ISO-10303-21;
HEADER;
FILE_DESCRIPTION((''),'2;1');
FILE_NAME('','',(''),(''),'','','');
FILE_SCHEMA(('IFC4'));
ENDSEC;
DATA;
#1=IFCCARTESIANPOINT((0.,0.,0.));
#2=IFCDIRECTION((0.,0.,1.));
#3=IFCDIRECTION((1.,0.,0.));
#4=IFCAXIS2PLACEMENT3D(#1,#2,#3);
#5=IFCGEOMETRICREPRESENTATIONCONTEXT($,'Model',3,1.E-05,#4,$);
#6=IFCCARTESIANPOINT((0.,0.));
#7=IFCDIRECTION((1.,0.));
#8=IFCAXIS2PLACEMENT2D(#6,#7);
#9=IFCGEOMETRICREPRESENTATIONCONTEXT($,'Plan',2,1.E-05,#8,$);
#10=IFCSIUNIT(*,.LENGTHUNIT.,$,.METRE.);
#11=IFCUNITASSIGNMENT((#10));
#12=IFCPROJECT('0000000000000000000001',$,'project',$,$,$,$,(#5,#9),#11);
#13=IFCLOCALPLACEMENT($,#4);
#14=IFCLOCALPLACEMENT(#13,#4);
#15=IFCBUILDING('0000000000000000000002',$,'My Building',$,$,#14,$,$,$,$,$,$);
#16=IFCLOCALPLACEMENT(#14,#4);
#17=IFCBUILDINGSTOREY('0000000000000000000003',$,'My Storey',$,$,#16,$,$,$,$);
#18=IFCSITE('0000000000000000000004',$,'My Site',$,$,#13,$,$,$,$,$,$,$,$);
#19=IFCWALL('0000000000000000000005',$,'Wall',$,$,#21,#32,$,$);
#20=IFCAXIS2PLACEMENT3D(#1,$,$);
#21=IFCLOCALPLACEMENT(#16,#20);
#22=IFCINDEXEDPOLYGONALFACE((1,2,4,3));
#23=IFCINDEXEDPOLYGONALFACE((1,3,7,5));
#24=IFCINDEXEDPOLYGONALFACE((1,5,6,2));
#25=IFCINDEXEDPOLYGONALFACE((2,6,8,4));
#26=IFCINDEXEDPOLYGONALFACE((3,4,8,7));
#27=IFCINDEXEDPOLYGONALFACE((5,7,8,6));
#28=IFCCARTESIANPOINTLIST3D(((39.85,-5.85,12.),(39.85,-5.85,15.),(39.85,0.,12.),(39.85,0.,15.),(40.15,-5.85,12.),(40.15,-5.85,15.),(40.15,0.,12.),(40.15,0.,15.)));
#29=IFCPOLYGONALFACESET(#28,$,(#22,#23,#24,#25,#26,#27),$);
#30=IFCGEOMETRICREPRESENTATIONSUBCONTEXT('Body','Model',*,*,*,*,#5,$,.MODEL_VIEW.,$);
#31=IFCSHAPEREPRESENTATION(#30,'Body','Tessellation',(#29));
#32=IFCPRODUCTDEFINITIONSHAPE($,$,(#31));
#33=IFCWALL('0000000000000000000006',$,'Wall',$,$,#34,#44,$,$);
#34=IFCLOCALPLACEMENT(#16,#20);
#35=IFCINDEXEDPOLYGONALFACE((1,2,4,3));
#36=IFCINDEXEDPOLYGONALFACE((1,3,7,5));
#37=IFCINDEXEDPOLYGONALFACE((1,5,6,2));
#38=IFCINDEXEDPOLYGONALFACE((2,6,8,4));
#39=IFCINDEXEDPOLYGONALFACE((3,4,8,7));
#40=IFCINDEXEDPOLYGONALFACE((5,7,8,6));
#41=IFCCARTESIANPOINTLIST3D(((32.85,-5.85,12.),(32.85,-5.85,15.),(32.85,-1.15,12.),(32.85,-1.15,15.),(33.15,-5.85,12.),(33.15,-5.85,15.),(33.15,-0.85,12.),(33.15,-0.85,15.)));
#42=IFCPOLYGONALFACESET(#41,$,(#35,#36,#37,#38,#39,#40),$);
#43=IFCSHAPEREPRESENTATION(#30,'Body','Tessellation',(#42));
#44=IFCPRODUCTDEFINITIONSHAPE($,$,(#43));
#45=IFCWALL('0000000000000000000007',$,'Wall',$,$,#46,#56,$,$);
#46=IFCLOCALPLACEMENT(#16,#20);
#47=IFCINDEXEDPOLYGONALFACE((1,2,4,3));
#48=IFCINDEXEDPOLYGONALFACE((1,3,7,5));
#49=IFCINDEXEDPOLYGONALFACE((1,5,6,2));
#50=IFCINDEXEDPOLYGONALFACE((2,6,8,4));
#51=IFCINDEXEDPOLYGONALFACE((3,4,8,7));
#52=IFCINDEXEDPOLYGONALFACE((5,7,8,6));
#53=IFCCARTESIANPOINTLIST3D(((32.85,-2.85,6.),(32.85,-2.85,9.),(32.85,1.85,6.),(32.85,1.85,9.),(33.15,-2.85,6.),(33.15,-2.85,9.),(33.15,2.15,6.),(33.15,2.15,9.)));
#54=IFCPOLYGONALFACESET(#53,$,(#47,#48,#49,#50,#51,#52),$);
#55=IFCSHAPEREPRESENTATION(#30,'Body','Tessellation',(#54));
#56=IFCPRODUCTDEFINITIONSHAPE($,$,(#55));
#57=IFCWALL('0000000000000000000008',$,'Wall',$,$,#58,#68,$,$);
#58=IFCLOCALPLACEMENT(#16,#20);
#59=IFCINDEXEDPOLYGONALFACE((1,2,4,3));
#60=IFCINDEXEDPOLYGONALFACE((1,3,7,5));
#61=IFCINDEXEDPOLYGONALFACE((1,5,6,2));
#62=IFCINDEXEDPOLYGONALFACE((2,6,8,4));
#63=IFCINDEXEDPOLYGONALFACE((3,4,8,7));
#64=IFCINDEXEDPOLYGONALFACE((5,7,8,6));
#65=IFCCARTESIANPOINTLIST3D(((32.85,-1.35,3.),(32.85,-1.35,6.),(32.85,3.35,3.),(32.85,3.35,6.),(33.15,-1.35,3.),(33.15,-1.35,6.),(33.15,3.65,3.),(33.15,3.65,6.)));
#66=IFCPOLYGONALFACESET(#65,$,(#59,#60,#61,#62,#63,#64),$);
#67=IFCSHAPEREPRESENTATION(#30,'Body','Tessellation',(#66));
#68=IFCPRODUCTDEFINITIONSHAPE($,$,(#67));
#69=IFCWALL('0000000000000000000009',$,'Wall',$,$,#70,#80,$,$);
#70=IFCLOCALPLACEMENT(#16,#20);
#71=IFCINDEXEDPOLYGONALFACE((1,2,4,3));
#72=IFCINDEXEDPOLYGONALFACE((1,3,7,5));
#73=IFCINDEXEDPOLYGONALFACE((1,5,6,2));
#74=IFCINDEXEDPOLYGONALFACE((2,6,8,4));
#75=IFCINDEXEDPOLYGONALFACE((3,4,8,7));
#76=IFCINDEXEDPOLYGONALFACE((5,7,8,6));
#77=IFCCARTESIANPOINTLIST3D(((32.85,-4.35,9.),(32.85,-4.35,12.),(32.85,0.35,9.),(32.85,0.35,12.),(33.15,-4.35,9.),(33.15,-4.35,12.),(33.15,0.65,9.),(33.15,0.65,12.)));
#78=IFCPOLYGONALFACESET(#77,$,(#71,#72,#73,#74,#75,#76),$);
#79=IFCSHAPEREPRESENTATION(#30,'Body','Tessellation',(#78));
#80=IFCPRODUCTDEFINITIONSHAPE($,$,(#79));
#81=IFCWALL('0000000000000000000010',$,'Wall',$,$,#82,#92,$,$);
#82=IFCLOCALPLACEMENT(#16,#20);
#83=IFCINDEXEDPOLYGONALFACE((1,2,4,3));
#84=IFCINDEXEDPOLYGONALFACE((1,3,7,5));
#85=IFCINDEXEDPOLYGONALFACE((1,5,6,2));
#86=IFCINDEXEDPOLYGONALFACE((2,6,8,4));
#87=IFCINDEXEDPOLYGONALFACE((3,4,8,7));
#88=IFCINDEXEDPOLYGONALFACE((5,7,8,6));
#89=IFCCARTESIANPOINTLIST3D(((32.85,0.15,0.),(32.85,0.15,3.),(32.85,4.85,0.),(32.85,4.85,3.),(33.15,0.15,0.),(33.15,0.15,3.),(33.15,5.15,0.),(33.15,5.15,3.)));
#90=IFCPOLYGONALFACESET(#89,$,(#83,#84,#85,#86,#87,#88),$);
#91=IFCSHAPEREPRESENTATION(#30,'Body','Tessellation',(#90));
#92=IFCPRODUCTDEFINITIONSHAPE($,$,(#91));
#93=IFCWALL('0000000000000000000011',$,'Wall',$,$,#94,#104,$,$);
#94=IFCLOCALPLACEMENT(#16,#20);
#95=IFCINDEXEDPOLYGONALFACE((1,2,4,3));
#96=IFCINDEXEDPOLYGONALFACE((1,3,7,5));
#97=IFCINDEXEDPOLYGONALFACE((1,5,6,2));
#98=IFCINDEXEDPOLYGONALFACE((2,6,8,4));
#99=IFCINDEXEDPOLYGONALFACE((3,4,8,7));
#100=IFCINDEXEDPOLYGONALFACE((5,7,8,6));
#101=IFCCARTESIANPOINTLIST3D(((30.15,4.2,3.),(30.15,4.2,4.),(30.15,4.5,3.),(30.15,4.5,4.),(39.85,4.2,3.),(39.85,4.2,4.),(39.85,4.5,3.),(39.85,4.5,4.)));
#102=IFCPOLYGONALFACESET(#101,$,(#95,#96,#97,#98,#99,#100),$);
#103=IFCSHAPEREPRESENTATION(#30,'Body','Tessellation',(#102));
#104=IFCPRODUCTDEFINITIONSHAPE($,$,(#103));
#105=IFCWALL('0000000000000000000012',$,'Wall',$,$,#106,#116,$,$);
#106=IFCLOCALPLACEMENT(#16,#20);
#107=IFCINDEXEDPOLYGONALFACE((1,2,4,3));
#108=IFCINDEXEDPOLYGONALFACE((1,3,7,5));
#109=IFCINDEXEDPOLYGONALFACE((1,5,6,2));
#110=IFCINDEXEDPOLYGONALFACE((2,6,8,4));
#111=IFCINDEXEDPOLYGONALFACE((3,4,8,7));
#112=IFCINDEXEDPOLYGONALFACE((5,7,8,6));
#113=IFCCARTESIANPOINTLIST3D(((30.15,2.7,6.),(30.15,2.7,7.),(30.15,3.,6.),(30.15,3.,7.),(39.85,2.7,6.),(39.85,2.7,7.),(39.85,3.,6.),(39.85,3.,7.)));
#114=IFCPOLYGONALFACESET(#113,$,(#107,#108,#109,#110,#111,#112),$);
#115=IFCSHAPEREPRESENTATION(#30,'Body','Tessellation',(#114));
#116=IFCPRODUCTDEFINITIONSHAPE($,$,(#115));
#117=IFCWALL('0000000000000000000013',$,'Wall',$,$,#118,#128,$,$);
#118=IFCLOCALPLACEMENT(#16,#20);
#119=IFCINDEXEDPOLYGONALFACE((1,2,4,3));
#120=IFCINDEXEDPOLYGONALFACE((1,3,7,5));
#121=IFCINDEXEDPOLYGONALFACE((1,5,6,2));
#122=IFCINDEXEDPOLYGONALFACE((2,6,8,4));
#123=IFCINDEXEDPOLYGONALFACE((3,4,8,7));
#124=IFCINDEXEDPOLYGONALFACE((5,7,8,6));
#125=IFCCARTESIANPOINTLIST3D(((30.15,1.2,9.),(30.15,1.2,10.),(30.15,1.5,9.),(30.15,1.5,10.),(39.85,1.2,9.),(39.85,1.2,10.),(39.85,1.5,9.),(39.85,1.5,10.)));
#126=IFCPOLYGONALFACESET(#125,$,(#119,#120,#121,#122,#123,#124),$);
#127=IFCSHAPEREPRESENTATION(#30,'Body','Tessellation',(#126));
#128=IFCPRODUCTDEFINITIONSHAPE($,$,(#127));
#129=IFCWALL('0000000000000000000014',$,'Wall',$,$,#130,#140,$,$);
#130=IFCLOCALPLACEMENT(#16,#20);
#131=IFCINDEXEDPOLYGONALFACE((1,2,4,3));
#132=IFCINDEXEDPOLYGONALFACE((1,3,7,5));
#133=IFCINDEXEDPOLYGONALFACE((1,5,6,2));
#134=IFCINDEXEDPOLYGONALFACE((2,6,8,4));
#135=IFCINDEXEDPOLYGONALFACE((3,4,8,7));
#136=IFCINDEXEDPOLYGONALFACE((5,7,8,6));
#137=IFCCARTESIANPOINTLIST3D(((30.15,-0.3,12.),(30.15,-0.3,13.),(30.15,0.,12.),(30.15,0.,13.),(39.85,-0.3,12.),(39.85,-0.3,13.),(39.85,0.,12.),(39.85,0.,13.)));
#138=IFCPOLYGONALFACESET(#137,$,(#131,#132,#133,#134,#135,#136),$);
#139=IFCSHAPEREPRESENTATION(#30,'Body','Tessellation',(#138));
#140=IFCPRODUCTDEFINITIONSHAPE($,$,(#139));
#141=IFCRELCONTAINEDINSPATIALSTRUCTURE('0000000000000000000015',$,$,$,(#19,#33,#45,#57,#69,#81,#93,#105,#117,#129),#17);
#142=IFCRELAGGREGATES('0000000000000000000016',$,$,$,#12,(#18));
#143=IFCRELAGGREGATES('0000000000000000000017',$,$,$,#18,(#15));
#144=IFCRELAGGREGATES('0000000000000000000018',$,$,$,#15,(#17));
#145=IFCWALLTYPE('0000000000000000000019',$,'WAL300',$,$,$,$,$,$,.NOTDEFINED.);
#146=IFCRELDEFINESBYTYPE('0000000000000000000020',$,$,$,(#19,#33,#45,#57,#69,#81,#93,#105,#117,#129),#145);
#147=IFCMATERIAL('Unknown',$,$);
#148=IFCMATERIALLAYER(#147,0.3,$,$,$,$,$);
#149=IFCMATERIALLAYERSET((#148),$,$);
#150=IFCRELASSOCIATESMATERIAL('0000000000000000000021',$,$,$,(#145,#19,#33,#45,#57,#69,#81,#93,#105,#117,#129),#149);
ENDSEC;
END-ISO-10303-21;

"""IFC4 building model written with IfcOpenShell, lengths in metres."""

from ifc_helpers import new_model, si_unit, frame, origin_with_axes, origin_2d_with_axis, place, context, subcontext, project, spatial, line, indexed_curve, outline, extrude, material, layer, layer_set, layer_usage, type_object, element, save


model = new_model("IFC4")

# Units and contexts
model_context = context("Model", 3, precision=1e-05, world=origin_with_axes())
plan_context = context("Plan", 2, precision=1e-05, world=origin_2d_with_axis())
body_context = subcontext(model_context, "Body", "Model", "MODEL_VIEW")
ifc_project = project(units=[si_unit("LENGTHUNIT", "METRE")], contexts=[model_context, plan_context])

# Site, building, storey
site_placement = place(None, origin_with_axes())
site = spatial("IfcSite", under=ifc_project, at=site_placement, Name="My Site")
building_placement = place(site_placement, origin_with_axes())
building = spatial("IfcBuilding", under=site, at=building_placement, Name="My Building")
storey_placement = place(building_placement, origin_with_axes())
storey = spatial("IfcBuildingStorey", under=building, at=storey_placement, Name="My Storey")

# Shared definitions
ifc_material = material(Name="Unknown")

# Walls
ifc_layer_1 = layer(ifc_material, 0.3)
ifc_layer_set_1 = layer_set([ifc_layer_1])
wall_type = type_object("IfcWallType", Name="WAL300", PredefinedType="NOTDEFINED", material=ifc_layer_set_1)
ifc_layer_usage_1 = layer_usage(ifc_layer_set_1, "AXIS2", "POSITIVE", -0.15)
wall_1_placement = place(storey_placement, frame((40.0, -6.0, 12.0), z_axis=(0.0, 0.0, 1.0), x_axis=(0.0, 1.0, 0.0)))
element("IfcWall", 1, at=wall_1_placement, inside=storey, type_object=wall_type, material=ifc_layer_usage_1, Name="Wall", context=body_context, shape_type="SweptSolid", body=[
    extrude(outline(indexed_curve([(0.15, -0.15), (0.15, 0.15), (6.0, 0.15), (6.0, -0.15)], segments=[line(1, 2, 3, 4, 1)])), origin_with_axes(), (0.0, 0.0, 1.0), 3.0),
])
ifc_layer_usage_2 = layer_usage(ifc_layer_set_1, "AXIS2", "POSITIVE", -0.15)
wall_2_placement = place(storey_placement, frame((33.0, -6.0, 12.0), z_axis=(0.0, 0.0, 1.0), x_axis=(0.0, 1.0, 0.0)))
element("IfcWall", 2, at=wall_2_placement, inside=storey, type_object=wall_type, material=ifc_layer_usage_2, Name="Wall", context=body_context, shape_type="SweptSolid", body=[
    extrude(outline(indexed_curve([(0.15, -0.15), (0.15, 0.15), (4.85, 0.15), (5.15, -0.15)], segments=[line(1, 2, 3, 4, 1)])), origin_with_axes(), (0.0, 0.0, 1.0), 3.0),
])
ifc_layer_usage_3 = layer_usage(ifc_layer_set_1, "AXIS2", "POSITIVE", -0.15)
wall_3_placement = place(storey_placement, frame((33.0, -3.0, 6.0), z_axis=(0.0, 0.0, 1.0), x_axis=(0.0, 1.0, 0.0)))
element("IfcWall", 3, at=wall_3_placement, inside=storey, type_object=wall_type, material=ifc_layer_usage_3, Name="Wall", context=body_context, shape_type="SweptSolid", body=[
    extrude(outline(indexed_curve([(0.15, -0.15), (0.15, 0.15), (4.85, 0.15), (5.15, -0.15)], segments=[line(1, 2, 3, 4, 1)])), origin_with_axes(), (0.0, 0.0, 1.0), 3.0),
])
ifc_layer_usage_4 = layer_usage(ifc_layer_set_1, "AXIS2", "POSITIVE", -0.15)
wall_4_placement = place(storey_placement, frame((33.0, -1.5, 3.0), z_axis=(0.0, 0.0, 1.0), x_axis=(0.0, 1.0, 0.0)))
element("IfcWall", 4, at=wall_4_placement, inside=storey, type_object=wall_type, material=ifc_layer_usage_4, Name="Wall", context=body_context, shape_type="SweptSolid", body=[
    extrude(outline(indexed_curve([(0.15, -0.15), (0.15, 0.15), (4.85, 0.15), (5.15, -0.15)], segments=[line(1, 2, 3, 4, 1)])), origin_with_axes(), (0.0, 0.0, 1.0), 3.0),
])
ifc_layer_usage_5 = layer_usage(ifc_layer_set_1, "AXIS2", "POSITIVE", -0.15)
wall_5_placement = place(storey_placement, frame((33.0, -4.5, 9.0), z_axis=(0.0, 0.0, 1.0), x_axis=(0.0, 1.0, 0.0)))
element("IfcWall", 5, at=wall_5_placement, inside=storey, type_object=wall_type, material=ifc_layer_usage_5, Name="Wall", context=body_context, shape_type="SweptSolid", body=[
    extrude(outline(indexed_curve([(0.15, -0.15), (0.15, 0.15), (4.85, 0.15), (5.15, -0.15)], segments=[line(1, 2, 3, 4, 1)])), origin_with_axes(), (0.0, 0.0, 1.0), 3.0),
])
ifc_layer_usage_6 = layer_usage(ifc_layer_set_1, "AXIS2", "POSITIVE", -0.15)
wall_6_placement = place(storey_placement, frame((33.0, 0.0, 0.0), z_axis=(0.0, 0.0, 1.0), x_axis=(0.0, 1.0, 0.0)))
element("IfcWall", 6, at=wall_6_placement, inside=storey, type_object=wall_type, material=ifc_layer_usage_6, Name="Wall", context=body_context, shape_type="SweptSolid", body=[
    extrude(outline(indexed_curve([(0.15, -0.15), (0.15, 0.15), (4.85, 0.15), (5.15, -0.15)], segments=[line(1, 2, 3, 4, 1)])), origin_with_axes(), (0.0, 0.0, 1.0), 3.0),
])
ifc_layer_usage_7 = layer_usage(ifc_layer_set_1, "AXIS2", "POSITIVE", -0.3)
wall_7_placement = place(storey_placement, frame((30.15, 4.5, 3.0), z_axis=(0.0, 0.0, 1.0), x_axis=(1.0, 0.0, 0.0)))
element("IfcWall", 7, at=wall_7_placement, inside=storey, type_object=wall_type, material=ifc_layer_usage_7, Name="Wall", context=body_context, shape_type="SweptSolid", body=[
    extrude(outline(indexed_curve([(0.0, -0.3), (0.0, 0.0), (9.7, 0.0), (9.7, -0.3)], segments=[line(1, 2, 3, 4, 1)])), origin_with_axes(), (0.0, 0.0, 1.0), 1.0),
])
ifc_layer_usage_8 = layer_usage(ifc_layer_set_1, "AXIS2", "POSITIVE", -0.3)
wall_8_placement = place(storey_placement, frame((30.15, 3.0, 6.0), z_axis=(0.0, 0.0, 1.0), x_axis=(1.0, 0.0, 0.0)))
element("IfcWall", 8, at=wall_8_placement, inside=storey, type_object=wall_type, material=ifc_layer_usage_8, Name="Wall", context=body_context, shape_type="SweptSolid", body=[
    extrude(outline(indexed_curve([(0.0, -0.3), (0.0, 0.0), (9.7, 0.0), (9.7, -0.3)], segments=[line(1, 2, 3, 4, 1)])), origin_with_axes(), (0.0, 0.0, 1.0), 1.0),
])
ifc_layer_usage_9 = layer_usage(ifc_layer_set_1, "AXIS2", "POSITIVE", -0.3)
wall_9_placement = place(storey_placement, frame((30.15, 1.5, 9.0), z_axis=(0.0, 0.0, 1.0), x_axis=(1.0, 0.0, 0.0)))
element("IfcWall", 9, at=wall_9_placement, inside=storey, type_object=wall_type, material=ifc_layer_usage_9, Name="Wall", context=body_context, shape_type="SweptSolid", body=[
    extrude(outline(indexed_curve([(0.0, -0.3), (0.0, 0.0), (9.7, 0.0), (9.7, -0.3)], segments=[line(1, 2, 3, 4, 1)])), origin_with_axes(), (0.0, 0.0, 1.0), 1.0),
])
ifc_layer_usage_10 = layer_usage(ifc_layer_set_1, "AXIS2", "POSITIVE", -0.3)
wall_10_placement = place(storey_placement, frame((30.15, 0.0, 12.0), z_axis=(0.0, 0.0, 1.0), x_axis=(1.0, 0.0, 0.0)))
element("IfcWall", 10, at=wall_10_placement, inside=storey, type_object=wall_type, material=ifc_layer_usage_10, Name="Wall", context=body_context, shape_type="SweptSolid", body=[
    extrude(outline(indexed_curve([(0.0, -0.3), (0.0, 0.0), (9.7, 0.0), (9.7, -0.3)], segments=[line(1, 2, 3, 4, 1)])), origin_with_axes(), (0.0, 0.0, 1.0), 1.0),
])

save(model, "model.ifc")
